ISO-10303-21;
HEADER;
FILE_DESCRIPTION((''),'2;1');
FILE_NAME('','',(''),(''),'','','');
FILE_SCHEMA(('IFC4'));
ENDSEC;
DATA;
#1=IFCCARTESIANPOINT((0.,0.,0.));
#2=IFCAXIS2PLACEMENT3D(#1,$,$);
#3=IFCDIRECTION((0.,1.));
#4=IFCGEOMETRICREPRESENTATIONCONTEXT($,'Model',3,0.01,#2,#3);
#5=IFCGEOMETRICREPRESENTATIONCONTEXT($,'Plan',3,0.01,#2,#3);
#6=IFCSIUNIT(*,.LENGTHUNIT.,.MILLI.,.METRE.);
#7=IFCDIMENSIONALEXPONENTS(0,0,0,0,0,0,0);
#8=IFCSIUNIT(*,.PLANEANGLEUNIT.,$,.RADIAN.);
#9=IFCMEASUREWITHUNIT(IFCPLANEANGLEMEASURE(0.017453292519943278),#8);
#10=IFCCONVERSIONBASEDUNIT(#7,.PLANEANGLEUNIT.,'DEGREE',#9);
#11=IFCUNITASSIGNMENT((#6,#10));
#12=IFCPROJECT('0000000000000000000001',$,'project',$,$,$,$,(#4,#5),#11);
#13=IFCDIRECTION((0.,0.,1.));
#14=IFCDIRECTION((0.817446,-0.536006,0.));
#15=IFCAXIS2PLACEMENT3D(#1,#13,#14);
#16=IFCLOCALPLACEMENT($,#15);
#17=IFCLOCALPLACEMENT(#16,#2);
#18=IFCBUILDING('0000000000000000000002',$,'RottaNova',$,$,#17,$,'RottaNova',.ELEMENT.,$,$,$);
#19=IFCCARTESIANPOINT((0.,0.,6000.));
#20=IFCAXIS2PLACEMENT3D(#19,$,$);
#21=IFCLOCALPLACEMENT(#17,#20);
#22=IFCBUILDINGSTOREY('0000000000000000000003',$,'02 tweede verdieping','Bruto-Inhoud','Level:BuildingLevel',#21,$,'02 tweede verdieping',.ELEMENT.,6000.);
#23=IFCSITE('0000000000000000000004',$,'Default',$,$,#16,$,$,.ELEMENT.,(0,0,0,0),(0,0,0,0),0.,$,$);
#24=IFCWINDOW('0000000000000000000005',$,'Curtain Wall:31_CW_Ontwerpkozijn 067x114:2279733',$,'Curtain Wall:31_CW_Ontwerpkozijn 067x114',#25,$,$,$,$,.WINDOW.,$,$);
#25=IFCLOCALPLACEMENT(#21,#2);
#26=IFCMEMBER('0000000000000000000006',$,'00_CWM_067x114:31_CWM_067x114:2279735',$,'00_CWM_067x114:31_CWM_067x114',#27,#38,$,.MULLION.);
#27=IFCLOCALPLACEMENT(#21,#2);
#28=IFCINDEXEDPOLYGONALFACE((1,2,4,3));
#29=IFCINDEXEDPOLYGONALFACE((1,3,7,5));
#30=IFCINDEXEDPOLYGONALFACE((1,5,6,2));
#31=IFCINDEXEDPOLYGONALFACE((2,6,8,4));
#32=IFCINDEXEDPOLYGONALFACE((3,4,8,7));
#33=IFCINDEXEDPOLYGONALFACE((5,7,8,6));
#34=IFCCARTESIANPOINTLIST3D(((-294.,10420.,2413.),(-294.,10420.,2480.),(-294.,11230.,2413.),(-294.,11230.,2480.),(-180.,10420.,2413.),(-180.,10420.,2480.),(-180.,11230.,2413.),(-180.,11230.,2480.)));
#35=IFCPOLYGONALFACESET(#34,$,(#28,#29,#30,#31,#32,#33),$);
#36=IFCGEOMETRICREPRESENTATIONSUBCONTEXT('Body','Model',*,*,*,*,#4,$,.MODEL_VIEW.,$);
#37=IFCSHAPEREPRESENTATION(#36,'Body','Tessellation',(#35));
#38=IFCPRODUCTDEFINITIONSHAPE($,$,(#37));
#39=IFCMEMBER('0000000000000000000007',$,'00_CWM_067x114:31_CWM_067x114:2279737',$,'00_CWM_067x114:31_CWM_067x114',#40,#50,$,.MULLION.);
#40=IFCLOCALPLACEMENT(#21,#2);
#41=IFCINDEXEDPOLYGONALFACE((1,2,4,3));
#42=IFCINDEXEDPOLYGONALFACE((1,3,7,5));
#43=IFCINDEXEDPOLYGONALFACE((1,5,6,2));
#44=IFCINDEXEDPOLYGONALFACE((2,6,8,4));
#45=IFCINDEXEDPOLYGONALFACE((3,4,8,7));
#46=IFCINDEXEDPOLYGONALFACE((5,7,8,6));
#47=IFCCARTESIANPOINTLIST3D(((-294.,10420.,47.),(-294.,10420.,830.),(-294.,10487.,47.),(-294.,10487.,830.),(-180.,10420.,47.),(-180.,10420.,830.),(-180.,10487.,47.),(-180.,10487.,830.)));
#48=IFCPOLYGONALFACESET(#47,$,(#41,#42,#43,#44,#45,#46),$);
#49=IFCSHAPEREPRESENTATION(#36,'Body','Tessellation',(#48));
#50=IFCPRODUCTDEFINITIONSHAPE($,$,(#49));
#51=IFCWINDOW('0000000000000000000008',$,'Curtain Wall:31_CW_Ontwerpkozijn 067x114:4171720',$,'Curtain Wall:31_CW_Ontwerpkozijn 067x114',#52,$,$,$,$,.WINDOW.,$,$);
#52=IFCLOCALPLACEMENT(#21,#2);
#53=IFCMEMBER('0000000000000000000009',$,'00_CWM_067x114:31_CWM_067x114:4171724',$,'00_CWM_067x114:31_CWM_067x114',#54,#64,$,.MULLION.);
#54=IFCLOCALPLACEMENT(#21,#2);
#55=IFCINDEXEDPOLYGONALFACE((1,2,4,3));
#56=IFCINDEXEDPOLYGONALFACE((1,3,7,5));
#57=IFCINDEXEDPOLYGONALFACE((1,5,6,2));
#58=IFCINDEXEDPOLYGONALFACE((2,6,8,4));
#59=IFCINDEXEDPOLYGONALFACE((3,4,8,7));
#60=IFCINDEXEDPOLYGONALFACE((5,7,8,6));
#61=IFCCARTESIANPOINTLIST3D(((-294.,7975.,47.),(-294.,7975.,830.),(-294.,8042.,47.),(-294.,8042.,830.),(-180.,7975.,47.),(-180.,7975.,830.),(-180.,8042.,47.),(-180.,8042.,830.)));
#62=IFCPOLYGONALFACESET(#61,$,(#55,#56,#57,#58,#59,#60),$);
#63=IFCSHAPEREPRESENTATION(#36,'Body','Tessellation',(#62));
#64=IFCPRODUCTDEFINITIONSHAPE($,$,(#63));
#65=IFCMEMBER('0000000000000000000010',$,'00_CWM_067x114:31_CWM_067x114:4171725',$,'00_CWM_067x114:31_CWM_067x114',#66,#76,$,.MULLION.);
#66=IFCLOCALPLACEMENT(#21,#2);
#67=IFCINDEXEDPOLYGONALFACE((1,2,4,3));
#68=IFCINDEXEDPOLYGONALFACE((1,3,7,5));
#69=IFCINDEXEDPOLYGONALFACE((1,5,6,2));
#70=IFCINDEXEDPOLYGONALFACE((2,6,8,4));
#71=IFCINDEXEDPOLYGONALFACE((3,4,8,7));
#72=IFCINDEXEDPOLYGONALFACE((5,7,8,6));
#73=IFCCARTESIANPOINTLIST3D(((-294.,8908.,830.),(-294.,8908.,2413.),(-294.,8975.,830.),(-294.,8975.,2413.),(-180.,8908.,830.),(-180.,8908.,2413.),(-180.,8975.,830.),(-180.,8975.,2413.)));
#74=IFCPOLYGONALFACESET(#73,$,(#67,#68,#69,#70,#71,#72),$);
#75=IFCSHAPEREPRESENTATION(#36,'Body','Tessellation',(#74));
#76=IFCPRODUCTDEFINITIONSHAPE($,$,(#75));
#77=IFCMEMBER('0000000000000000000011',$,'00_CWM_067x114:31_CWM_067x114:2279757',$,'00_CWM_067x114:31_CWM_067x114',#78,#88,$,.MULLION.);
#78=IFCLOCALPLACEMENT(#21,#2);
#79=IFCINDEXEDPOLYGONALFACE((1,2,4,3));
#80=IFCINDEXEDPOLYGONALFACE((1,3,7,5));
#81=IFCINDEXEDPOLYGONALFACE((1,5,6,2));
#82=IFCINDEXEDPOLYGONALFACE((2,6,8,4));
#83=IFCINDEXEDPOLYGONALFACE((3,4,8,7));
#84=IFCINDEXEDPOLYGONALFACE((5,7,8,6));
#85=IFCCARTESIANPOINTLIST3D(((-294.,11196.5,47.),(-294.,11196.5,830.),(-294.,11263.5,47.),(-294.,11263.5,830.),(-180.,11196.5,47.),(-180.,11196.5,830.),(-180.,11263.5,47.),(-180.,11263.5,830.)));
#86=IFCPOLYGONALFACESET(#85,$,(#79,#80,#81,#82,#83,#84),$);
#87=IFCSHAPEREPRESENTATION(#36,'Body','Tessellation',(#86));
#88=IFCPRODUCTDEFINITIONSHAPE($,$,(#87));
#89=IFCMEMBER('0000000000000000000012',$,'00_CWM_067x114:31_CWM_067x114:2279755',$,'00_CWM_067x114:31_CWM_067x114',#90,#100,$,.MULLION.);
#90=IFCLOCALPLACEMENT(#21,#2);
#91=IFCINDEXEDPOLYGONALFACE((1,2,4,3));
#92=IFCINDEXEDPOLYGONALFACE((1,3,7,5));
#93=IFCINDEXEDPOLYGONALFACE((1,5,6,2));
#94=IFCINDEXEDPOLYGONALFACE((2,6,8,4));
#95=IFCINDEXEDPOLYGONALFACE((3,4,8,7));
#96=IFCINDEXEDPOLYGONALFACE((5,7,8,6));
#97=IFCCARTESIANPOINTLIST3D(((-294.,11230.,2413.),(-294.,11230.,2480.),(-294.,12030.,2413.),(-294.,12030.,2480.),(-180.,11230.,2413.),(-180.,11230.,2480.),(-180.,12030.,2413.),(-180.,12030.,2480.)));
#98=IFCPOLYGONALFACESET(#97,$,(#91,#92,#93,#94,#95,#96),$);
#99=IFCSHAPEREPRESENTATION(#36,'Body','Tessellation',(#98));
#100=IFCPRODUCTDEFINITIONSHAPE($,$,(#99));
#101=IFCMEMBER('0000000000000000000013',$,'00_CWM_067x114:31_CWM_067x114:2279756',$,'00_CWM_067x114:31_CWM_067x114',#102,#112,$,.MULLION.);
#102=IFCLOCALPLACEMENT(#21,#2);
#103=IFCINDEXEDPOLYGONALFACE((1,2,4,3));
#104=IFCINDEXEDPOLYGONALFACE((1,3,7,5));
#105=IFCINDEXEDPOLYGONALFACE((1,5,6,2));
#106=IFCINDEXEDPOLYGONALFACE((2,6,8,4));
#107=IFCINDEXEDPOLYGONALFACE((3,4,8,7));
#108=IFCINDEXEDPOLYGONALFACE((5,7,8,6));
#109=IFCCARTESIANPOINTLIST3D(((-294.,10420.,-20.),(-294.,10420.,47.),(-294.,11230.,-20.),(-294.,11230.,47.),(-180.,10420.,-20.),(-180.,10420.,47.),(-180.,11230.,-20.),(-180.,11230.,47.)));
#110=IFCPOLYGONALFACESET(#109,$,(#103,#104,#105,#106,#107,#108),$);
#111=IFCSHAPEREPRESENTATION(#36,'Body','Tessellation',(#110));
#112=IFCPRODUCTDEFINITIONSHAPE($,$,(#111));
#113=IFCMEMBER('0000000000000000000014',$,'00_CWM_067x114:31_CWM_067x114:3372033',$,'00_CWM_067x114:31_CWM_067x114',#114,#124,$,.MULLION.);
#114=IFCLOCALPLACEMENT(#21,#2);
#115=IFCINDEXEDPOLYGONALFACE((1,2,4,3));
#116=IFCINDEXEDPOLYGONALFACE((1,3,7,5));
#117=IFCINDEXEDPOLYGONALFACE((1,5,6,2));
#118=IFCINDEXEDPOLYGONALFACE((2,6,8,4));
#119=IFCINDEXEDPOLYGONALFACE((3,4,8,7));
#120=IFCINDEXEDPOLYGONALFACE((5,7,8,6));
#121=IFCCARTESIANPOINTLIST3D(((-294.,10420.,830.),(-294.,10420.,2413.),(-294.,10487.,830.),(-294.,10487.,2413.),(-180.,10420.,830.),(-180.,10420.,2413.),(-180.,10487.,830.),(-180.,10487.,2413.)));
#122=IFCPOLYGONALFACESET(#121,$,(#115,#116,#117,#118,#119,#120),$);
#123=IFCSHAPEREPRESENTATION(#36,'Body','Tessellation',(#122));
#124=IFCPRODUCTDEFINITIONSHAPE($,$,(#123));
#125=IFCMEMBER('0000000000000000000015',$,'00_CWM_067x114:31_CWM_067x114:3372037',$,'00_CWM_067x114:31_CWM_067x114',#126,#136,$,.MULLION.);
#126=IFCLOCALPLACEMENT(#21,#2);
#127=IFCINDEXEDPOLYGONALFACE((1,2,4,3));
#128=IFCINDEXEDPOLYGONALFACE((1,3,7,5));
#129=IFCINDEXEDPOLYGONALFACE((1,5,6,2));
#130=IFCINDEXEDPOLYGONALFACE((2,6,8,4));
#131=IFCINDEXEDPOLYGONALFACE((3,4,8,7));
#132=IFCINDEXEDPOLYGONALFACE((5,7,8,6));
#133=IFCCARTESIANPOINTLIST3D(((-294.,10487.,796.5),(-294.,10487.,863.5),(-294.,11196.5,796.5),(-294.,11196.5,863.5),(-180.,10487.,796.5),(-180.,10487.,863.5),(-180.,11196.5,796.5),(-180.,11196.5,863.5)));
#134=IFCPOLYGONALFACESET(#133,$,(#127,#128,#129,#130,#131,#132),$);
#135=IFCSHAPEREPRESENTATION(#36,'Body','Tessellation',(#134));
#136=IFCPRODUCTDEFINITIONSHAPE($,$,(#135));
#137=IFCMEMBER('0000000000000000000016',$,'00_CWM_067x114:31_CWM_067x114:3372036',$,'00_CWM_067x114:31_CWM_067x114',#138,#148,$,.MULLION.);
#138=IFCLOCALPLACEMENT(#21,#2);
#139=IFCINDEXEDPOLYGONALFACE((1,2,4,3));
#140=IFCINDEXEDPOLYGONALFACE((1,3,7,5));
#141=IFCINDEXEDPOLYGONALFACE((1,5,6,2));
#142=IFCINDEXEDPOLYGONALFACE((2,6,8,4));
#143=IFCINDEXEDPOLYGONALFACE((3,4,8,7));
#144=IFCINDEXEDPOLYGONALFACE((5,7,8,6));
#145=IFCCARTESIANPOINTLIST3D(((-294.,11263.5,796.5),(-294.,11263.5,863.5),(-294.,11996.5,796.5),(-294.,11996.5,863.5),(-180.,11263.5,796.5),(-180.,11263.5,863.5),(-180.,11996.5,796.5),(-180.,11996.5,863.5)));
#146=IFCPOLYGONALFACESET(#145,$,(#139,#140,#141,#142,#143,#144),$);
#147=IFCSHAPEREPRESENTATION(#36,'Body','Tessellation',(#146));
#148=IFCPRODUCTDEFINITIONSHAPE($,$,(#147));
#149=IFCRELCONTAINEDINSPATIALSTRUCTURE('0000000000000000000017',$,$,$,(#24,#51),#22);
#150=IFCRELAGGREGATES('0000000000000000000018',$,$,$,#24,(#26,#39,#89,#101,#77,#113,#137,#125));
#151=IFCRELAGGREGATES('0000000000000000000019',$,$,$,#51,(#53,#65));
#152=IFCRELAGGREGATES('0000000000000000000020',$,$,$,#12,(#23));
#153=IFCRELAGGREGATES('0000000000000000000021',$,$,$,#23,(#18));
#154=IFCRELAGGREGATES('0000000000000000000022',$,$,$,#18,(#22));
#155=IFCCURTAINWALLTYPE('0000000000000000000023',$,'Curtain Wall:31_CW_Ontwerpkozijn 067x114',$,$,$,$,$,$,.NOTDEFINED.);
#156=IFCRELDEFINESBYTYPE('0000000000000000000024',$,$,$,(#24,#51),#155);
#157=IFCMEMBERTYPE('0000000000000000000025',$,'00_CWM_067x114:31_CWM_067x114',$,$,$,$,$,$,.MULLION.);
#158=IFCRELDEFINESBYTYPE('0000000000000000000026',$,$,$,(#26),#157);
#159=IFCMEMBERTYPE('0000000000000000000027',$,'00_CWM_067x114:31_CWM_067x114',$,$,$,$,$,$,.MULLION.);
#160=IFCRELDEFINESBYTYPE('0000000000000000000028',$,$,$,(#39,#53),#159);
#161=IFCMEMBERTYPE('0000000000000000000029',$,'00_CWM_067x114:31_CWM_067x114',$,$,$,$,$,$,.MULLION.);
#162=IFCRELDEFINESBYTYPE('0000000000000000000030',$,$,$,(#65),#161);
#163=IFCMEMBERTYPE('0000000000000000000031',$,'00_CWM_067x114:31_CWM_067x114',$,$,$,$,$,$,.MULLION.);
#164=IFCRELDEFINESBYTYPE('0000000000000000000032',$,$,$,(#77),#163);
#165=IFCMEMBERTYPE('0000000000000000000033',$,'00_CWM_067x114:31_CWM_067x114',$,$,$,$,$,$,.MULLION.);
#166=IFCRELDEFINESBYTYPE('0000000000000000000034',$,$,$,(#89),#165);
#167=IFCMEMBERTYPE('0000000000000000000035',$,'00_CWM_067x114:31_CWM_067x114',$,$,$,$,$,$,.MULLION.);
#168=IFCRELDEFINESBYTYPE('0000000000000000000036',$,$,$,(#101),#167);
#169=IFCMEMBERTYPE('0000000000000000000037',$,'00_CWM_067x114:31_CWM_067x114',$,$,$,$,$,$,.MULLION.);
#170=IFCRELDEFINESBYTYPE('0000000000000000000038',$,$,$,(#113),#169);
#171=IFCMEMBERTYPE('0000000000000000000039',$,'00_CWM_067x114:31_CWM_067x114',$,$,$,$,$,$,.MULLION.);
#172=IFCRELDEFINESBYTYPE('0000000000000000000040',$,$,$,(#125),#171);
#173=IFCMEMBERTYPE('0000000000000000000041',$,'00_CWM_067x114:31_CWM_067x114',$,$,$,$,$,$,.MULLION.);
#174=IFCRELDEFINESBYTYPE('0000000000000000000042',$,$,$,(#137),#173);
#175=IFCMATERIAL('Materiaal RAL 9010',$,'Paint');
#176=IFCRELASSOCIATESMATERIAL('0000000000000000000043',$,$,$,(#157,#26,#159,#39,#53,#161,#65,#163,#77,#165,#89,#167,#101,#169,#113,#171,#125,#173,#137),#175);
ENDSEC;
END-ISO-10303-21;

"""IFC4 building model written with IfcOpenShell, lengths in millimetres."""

from ifc_helpers import new_model, entity, si_unit, converted_unit, direction, frame, origin, place, context, subcontext, project, spatial, indexed_curve, outline, extrude, source, transform, mapped, material, type_object, type_shapes, element, aggregate, save


model = new_model("IFC4")

# Units and contexts
model_context = context("Model", 3, precision=0.01, world=origin(), true_north=direction((0.0, 1.0)))
plan_context = context("Plan", 3, precision=0.01, world=origin(), true_north=direction((0.0, 1.0)))
body_context = subcontext(model_context, "Body", "Model", "MODEL_VIEW")
ifc_project = project(units=[si_unit("LENGTHUNIT", "METRE", prefix="MILLI"), converted_unit("PLANEANGLEUNIT", "DEGREE", entity("IfcPlaneAngleMeasure", 0.017453292519943278), si_unit("PLANEANGLEUNIT", "RADIAN"), dimensions=[0, 0, 0, 0, 0, 0, 0])], contexts=[model_context, plan_context])

# Site, building, storey
site_placement = place(None, frame((0.0, 0.0, 0.0), z_axis=(0.0, 0.0, 1.0), x_axis=(0.817446, -0.536006, 0.0)))
site = spatial("IfcSite", under=ifc_project, at=site_placement, Name="Default", CompositionType="ELEMENT", RefLatitude=(0, 0, 0, 0), RefLongitude=(0, 0, 0, 0), RefElevation=0.0)
building_placement = place(site_placement, origin())
building = spatial("IfcBuilding", under=site, at=building_placement, Name="RottaNova", LongName="RottaNova", CompositionType="ELEMENT")
storey_placement = place(building_placement, frame((0.0, 0.0, 6000.0)))
storey = spatial("IfcBuildingStorey", under=building, at=storey_placement, Name="02 tweede verdieping", Description="Bruto-Inhoud", ObjectType="Level:BuildingLevel", LongName="02 tweede verdieping", CompositionType="ELEMENT", Elevation=6000.0)

# Windows, members
curtain_wall_type = type_object("IfcCurtainWallType", Name="Curtain Wall:31_CW_Ontwerpkozijn 067x114", PredefinedType="NOTDEFINED")
window_1_placement = place(storey_placement, frame((0.0, 0.0, -6000.0)))
window_1 = element("IfcWindow", 1, at=window_1_placement, inside=storey, type_object=curtain_wall_type, Name="Curtain Wall:31_CW_Ontwerpkozijn 067x114:2279733", ObjectType="Curtain Wall:31_CW_Ontwerpkozijn 067x114", PredefinedType="WINDOW")
ifc_material_1 = material(Name="Materiaal RAL 9010", Category="Paint")
member_type_1 = type_object("IfcMemberType", Name="00_CWM_067x114:31_CWM_067x114", PredefinedType="MULLION", material=ifc_material_1)
shared_shape_1 = source(origin(), body_context, "Body", "SweptSolid", [
    extrude(outline(indexed_curve([(-33.5, -57.0), (33.5, -57.0), (33.5, 57.0), (-33.5, 57.0), (-33.5, -57.0)], self_intersect=False)), frame((-33.5, 57.0, -810.0), z_axis=(0.0, 0.0, 1.0), x_axis=(-1.0, 0.0, 0.0)), (0.0, 0.0, 1.0), 810.0),
])
type_shapes(member_type_1, [shared_shape_1])
member_1_placement = place(window_1_placement, frame((-180.0, 10420.0, 8480.0), z_axis=(0.0, -1.0, 0.0), x_axis=(0.0, 0.0, 1.0)))
member_1 = element("IfcMember", 2, at=member_1_placement, type_object=member_type_1, material=ifc_material_1, Name="00_CWM_067x114:31_CWM_067x114:2279735", ObjectType="00_CWM_067x114:31_CWM_067x114", PredefinedType="MULLION", context=body_context, shape_type="MappedRepresentation", body=[
    mapped(shared_shape_1, transform((0.0, 0.0, 0.0), scale=1.0)),
])
member_type_2 = type_object("IfcMemberType", Name="00_CWM_067x114:31_CWM_067x114", PredefinedType="MULLION", material=ifc_material_1)
shared_shape_2 = source(origin(), body_context, "Body", "SweptSolid", [
    extrude(outline(indexed_curve([(-33.5, -57.0), (33.5, -57.0), (33.5, 57.0), (-33.5, 57.0), (-33.5, -57.0)], self_intersect=False)), frame((-33.5, 57.0, -783.0), z_axis=(0.0, 0.0, 1.0), x_axis=(-1.0, 0.0, 0.0)), (0.0, 0.0, 1.0), 783.0),
])
type_shapes(member_type_2, [shared_shape_2])
member_2_placement = place(window_1_placement, frame((-180.0, 10420.0, 6047.0), z_axis=(0.0, 0.0, -1.0), x_axis=(0.0, -1.0, 0.0)))
member_2 = element("IfcMember", 3, at=member_2_placement, type_object=member_type_2, material=ifc_material_1, Name="00_CWM_067x114:31_CWM_067x114:2279737", ObjectType="00_CWM_067x114:31_CWM_067x114", PredefinedType="MULLION", context=body_context, shape_type="MappedRepresentation", body=[
    mapped(shared_shape_2, transform((0.0, 0.0, 0.0), scale=1.0)),
])
window_2_placement = place(storey_placement, frame((0.0, 0.0, -6000.0)))
window_2 = element("IfcWindow", 4, at=window_2_placement, inside=storey, type_object=curtain_wall_type, Name="Curtain Wall:31_CW_Ontwerpkozijn 067x114:4171720", ObjectType="Curtain Wall:31_CW_Ontwerpkozijn 067x114", PredefinedType="WINDOW")
member_3_placement = place(window_2_placement, frame((-180.0, 7975.0, 6047.0), z_axis=(0.0, 0.0, -1.0), x_axis=(0.0, -1.0, 0.0)))
member_3 = element("IfcMember", 5, at=member_3_placement, type_object=member_type_2, material=ifc_material_1, Name="00_CWM_067x114:31_CWM_067x114:4171724", ObjectType="00_CWM_067x114:31_CWM_067x114", PredefinedType="MULLION", context=body_context, shape_type="MappedRepresentation", body=[
    mapped(shared_shape_2, transform((0.0, 0.0, 0.0), scale=1.0)),
])
member_type_3 = type_object("IfcMemberType", Name="00_CWM_067x114:31_CWM_067x114", PredefinedType="MULLION", material=ifc_material_1)
shared_shape_3 = source(origin(), body_context, "Body", "SweptSolid", [
    extrude(outline(indexed_curve([(-33.5, -57.0), (33.5, -57.0), (33.5, 57.0), (-33.5, 57.0), (-33.5, -57.0)], self_intersect=False)), frame((-33.5, 57.0, -1583.0), z_axis=(0.0, 0.0, 1.0), x_axis=(-1.0, 0.0, 0.0)), (0.0, 0.0, 1.0), 1583.0),
])
type_shapes(member_type_3, [shared_shape_3])
member_4_placement = place(window_2_placement, frame((-180.0, 8975.0, 8413.0), z_axis=(0.0, 0.0, 1.0), x_axis=(0.0, 1.0, 0.0)))
member_4 = element("IfcMember", 6, at=member_4_placement, type_object=member_type_3, material=ifc_material_1, Name="00_CWM_067x114:31_CWM_067x114:4171725", ObjectType="00_CWM_067x114:31_CWM_067x114", PredefinedType="MULLION", context=body_context, shape_type="MappedRepresentation", body=[
    mapped(shared_shape_3, transform((0.0, 0.0, 0.0), scale=1.0)),
])

# Members
member_type_4 = type_object("IfcMemberType", Name="00_CWM_067x114:31_CWM_067x114", PredefinedType="MULLION", material=ifc_material_1)
shared_shape_4 = source(origin(), body_context, "Body", "SweptSolid", [
    extrude(outline(indexed_curve([(-33.5, -57.0), (33.5, -57.0), (33.5, 57.0), (-33.5, 57.0), (-33.5, -57.0)], self_intersect=False)), frame((0.0, 57.0, -783.0), z_axis=(0.0, 0.0, 1.0), x_axis=(-1.0, 0.0, 0.0)), (0.0, 0.0, 1.0), 783.0),
])
type_shapes(member_type_4, [shared_shape_4])
member_5_placement = place(window_1_placement, frame((-180.0, 11230.0, 6047.0), z_axis=(0.0, 0.0, -1.0), x_axis=(0.0, -1.0, 0.0)))
member_5 = element("IfcMember", 7, at=member_5_placement, type_object=member_type_4, material=ifc_material_1, Name="00_CWM_067x114:31_CWM_067x114:2279757", ObjectType="00_CWM_067x114:31_CWM_067x114", PredefinedType="MULLION", context=body_context, shape_type="MappedRepresentation", body=[
    mapped(shared_shape_4, transform((0.0, 0.0, 0.0), scale=1.0)),
])
member_type_5 = type_object("IfcMemberType", Name="00_CWM_067x114:31_CWM_067x114", PredefinedType="MULLION", material=ifc_material_1)
shared_shape_5 = source(origin(), body_context, "Body", "SweptSolid", [
    extrude(outline(indexed_curve([(-33.5, -57.0), (33.5, -57.0), (33.5, 57.0), (-33.5, 57.0), (-33.5, -57.0)], self_intersect=False)), frame((-33.5, 57.0, -800.0), z_axis=(0.0, 0.0, 1.0), x_axis=(-1.0, 0.0, 0.0)), (0.0, 0.0, 1.0), 800.0),
])
type_shapes(member_type_5, [shared_shape_5])
member_6_placement = place(window_1_placement, frame((-180.0, 11230.0, 8480.0), z_axis=(0.0, -1.0, 0.0), x_axis=(0.0, 0.0, 1.0)))
member_6 = element("IfcMember", 8, at=member_6_placement, type_object=member_type_5, material=ifc_material_1, Name="00_CWM_067x114:31_CWM_067x114:2279755", ObjectType="00_CWM_067x114:31_CWM_067x114", PredefinedType="MULLION", context=body_context, shape_type="MappedRepresentation", body=[
    mapped(shared_shape_5, transform((0.0, 0.0, 0.0), scale=1.0)),
])
member_type_6 = type_object("IfcMemberType", Name="00_CWM_067x114:31_CWM_067x114", PredefinedType="MULLION", material=ifc_material_1)
shared_shape_6 = source(origin(), body_context, "Body", "SweptSolid", [
    extrude(outline(indexed_curve([(-33.5, -57.0), (33.5, -57.0), (33.5, 57.0), (-33.5, 57.0), (-33.5, -57.0)], self_intersect=False)), frame((-33.5, 57.0, -810.0), z_axis=(0.0, 0.0, 1.0), x_axis=(-1.0, 0.0, 0.0)), (0.0, 0.0, 1.0), 810.0),
])
type_shapes(member_type_6, [shared_shape_6])
member_7_placement = place(window_1_placement, frame((-180.0, 11230.0, 5980.0), z_axis=(0.0, 1.0, 0.0), x_axis=(0.0, 0.0, -1.0)))
member_7 = element("IfcMember", 9, at=member_7_placement, type_object=member_type_6, material=ifc_material_1, Name="00_CWM_067x114:31_CWM_067x114:2279756", ObjectType="00_CWM_067x114:31_CWM_067x114", PredefinedType="MULLION", context=body_context, shape_type="MappedRepresentation", body=[
    mapped(shared_shape_6, transform((0.0, 0.0, 0.0), scale=1.0)),
])
member_type_7 = type_object("IfcMemberType", Name="00_CWM_067x114:31_CWM_067x114", PredefinedType="MULLION", material=ifc_material_1)
shared_shape_7 = source(origin(), body_context, "Body", "SweptSolid", [
    extrude(outline(indexed_curve([(-33.5, -57.0), (33.5, -57.0), (33.5, 57.0), (-33.5, 57.0), (-33.5, -57.0)], self_intersect=False)), frame((-33.5, 57.0, -1583.0), z_axis=(0.0, 0.0, 1.0), x_axis=(-1.0, 0.0, 0.0)), (0.0, 0.0, 1.0), 1583.0),
])
type_shapes(member_type_7, [shared_shape_7])
member_8_placement = place(window_1_placement, frame((-180.0, 10420.0, 6830.0), z_axis=(0.0, 0.0, -1.0), x_axis=(0.0, -1.0, 0.0)))
member_8 = element("IfcMember", 10, at=member_8_placement, type_object=member_type_7, material=ifc_material_1, Name="00_CWM_067x114:31_CWM_067x114:3372033", ObjectType="00_CWM_067x114:31_CWM_067x114", PredefinedType="MULLION", context=body_context, shape_type="MappedRepresentation", body=[
    mapped(shared_shape_7, transform((0.0, 0.0, 0.0), scale=1.0)),
])
member_type_8 = type_object("IfcMemberType", Name="00_CWM_067x114:31_CWM_067x114", PredefinedType="MULLION", material=ifc_material_1)
shared_shape_8 = source(origin(), body_context, "Body", "SweptSolid", [
    extrude(outline(indexed_curve([(-33.5, -57.0), (33.5, -57.0), (33.5, 57.0), (-33.5, 57.0), (-33.5, -57.0)], self_intersect=False)), frame((0.0, 57.0, -709.5), z_axis=(0.0, 0.0, 1.0), x_axis=(-1.0, 0.0, 0.0)), (0.0, 0.0, 1.0), 709.5),
])
type_shapes(member_type_8, [shared_shape_8])
member_9_placement = place(window_1_placement, frame((-180.0, 10487.0, 6830.0), z_axis=(0.0, -1.0, 0.0), x_axis=(0.0, 0.0, 1.0)))
member_9 = element("IfcMember", 11, at=member_9_placement, type_object=member_type_8, material=ifc_material_1, Name="00_CWM_067x114:31_CWM_067x114:3372037", ObjectType="00_CWM_067x114:31_CWM_067x114", PredefinedType="MULLION", context=body_context, shape_type="MappedRepresentation", body=[
    mapped(shared_shape_8, transform((0.0, 0.0, 0.0), scale=1.0)),
])
member_type_9 = type_object("IfcMemberType", Name="00_CWM_067x114:31_CWM_067x114", PredefinedType="MULLION", material=ifc_material_1)
shared_shape_9 = source(origin(), body_context, "Body", "SweptSolid", [
    extrude(outline(indexed_curve([(-33.5, -57.0), (33.5, -57.0), (33.5, 57.0), (-33.5, 57.0), (-33.5, -57.0)], self_intersect=False)), frame((0.0, 57.0, -733.0), z_axis=(0.0, 0.0, 1.0), x_axis=(-1.0, 0.0, 0.0)), (0.0, 0.0, 1.0), 733.0),
])
type_shapes(member_type_9, [shared_shape_9])
member_10_placement = place(window_1_placement, frame((-180.0, 11263.5, 6830.0), z_axis=(0.0, -1.0, 0.0), x_axis=(0.0, 0.0, 1.0)))
member_10 = element("IfcMember", 12, at=member_10_placement, type_object=member_type_9, material=ifc_material_1, Name="00_CWM_067x114:31_CWM_067x114:3372036", ObjectType="00_CWM_067x114:31_CWM_067x114", PredefinedType="MULLION", context=body_context, shape_type="MappedRepresentation", body=[
    mapped(shared_shape_9, transform((0.0, 0.0, 0.0), scale=1.0)),
])

aggregate(window_1, [member_1, member_2, member_6, member_7, member_5, member_8, member_10, member_9])
aggregate(window_2, [member_3, member_4])

save(model, "model.ifc")
